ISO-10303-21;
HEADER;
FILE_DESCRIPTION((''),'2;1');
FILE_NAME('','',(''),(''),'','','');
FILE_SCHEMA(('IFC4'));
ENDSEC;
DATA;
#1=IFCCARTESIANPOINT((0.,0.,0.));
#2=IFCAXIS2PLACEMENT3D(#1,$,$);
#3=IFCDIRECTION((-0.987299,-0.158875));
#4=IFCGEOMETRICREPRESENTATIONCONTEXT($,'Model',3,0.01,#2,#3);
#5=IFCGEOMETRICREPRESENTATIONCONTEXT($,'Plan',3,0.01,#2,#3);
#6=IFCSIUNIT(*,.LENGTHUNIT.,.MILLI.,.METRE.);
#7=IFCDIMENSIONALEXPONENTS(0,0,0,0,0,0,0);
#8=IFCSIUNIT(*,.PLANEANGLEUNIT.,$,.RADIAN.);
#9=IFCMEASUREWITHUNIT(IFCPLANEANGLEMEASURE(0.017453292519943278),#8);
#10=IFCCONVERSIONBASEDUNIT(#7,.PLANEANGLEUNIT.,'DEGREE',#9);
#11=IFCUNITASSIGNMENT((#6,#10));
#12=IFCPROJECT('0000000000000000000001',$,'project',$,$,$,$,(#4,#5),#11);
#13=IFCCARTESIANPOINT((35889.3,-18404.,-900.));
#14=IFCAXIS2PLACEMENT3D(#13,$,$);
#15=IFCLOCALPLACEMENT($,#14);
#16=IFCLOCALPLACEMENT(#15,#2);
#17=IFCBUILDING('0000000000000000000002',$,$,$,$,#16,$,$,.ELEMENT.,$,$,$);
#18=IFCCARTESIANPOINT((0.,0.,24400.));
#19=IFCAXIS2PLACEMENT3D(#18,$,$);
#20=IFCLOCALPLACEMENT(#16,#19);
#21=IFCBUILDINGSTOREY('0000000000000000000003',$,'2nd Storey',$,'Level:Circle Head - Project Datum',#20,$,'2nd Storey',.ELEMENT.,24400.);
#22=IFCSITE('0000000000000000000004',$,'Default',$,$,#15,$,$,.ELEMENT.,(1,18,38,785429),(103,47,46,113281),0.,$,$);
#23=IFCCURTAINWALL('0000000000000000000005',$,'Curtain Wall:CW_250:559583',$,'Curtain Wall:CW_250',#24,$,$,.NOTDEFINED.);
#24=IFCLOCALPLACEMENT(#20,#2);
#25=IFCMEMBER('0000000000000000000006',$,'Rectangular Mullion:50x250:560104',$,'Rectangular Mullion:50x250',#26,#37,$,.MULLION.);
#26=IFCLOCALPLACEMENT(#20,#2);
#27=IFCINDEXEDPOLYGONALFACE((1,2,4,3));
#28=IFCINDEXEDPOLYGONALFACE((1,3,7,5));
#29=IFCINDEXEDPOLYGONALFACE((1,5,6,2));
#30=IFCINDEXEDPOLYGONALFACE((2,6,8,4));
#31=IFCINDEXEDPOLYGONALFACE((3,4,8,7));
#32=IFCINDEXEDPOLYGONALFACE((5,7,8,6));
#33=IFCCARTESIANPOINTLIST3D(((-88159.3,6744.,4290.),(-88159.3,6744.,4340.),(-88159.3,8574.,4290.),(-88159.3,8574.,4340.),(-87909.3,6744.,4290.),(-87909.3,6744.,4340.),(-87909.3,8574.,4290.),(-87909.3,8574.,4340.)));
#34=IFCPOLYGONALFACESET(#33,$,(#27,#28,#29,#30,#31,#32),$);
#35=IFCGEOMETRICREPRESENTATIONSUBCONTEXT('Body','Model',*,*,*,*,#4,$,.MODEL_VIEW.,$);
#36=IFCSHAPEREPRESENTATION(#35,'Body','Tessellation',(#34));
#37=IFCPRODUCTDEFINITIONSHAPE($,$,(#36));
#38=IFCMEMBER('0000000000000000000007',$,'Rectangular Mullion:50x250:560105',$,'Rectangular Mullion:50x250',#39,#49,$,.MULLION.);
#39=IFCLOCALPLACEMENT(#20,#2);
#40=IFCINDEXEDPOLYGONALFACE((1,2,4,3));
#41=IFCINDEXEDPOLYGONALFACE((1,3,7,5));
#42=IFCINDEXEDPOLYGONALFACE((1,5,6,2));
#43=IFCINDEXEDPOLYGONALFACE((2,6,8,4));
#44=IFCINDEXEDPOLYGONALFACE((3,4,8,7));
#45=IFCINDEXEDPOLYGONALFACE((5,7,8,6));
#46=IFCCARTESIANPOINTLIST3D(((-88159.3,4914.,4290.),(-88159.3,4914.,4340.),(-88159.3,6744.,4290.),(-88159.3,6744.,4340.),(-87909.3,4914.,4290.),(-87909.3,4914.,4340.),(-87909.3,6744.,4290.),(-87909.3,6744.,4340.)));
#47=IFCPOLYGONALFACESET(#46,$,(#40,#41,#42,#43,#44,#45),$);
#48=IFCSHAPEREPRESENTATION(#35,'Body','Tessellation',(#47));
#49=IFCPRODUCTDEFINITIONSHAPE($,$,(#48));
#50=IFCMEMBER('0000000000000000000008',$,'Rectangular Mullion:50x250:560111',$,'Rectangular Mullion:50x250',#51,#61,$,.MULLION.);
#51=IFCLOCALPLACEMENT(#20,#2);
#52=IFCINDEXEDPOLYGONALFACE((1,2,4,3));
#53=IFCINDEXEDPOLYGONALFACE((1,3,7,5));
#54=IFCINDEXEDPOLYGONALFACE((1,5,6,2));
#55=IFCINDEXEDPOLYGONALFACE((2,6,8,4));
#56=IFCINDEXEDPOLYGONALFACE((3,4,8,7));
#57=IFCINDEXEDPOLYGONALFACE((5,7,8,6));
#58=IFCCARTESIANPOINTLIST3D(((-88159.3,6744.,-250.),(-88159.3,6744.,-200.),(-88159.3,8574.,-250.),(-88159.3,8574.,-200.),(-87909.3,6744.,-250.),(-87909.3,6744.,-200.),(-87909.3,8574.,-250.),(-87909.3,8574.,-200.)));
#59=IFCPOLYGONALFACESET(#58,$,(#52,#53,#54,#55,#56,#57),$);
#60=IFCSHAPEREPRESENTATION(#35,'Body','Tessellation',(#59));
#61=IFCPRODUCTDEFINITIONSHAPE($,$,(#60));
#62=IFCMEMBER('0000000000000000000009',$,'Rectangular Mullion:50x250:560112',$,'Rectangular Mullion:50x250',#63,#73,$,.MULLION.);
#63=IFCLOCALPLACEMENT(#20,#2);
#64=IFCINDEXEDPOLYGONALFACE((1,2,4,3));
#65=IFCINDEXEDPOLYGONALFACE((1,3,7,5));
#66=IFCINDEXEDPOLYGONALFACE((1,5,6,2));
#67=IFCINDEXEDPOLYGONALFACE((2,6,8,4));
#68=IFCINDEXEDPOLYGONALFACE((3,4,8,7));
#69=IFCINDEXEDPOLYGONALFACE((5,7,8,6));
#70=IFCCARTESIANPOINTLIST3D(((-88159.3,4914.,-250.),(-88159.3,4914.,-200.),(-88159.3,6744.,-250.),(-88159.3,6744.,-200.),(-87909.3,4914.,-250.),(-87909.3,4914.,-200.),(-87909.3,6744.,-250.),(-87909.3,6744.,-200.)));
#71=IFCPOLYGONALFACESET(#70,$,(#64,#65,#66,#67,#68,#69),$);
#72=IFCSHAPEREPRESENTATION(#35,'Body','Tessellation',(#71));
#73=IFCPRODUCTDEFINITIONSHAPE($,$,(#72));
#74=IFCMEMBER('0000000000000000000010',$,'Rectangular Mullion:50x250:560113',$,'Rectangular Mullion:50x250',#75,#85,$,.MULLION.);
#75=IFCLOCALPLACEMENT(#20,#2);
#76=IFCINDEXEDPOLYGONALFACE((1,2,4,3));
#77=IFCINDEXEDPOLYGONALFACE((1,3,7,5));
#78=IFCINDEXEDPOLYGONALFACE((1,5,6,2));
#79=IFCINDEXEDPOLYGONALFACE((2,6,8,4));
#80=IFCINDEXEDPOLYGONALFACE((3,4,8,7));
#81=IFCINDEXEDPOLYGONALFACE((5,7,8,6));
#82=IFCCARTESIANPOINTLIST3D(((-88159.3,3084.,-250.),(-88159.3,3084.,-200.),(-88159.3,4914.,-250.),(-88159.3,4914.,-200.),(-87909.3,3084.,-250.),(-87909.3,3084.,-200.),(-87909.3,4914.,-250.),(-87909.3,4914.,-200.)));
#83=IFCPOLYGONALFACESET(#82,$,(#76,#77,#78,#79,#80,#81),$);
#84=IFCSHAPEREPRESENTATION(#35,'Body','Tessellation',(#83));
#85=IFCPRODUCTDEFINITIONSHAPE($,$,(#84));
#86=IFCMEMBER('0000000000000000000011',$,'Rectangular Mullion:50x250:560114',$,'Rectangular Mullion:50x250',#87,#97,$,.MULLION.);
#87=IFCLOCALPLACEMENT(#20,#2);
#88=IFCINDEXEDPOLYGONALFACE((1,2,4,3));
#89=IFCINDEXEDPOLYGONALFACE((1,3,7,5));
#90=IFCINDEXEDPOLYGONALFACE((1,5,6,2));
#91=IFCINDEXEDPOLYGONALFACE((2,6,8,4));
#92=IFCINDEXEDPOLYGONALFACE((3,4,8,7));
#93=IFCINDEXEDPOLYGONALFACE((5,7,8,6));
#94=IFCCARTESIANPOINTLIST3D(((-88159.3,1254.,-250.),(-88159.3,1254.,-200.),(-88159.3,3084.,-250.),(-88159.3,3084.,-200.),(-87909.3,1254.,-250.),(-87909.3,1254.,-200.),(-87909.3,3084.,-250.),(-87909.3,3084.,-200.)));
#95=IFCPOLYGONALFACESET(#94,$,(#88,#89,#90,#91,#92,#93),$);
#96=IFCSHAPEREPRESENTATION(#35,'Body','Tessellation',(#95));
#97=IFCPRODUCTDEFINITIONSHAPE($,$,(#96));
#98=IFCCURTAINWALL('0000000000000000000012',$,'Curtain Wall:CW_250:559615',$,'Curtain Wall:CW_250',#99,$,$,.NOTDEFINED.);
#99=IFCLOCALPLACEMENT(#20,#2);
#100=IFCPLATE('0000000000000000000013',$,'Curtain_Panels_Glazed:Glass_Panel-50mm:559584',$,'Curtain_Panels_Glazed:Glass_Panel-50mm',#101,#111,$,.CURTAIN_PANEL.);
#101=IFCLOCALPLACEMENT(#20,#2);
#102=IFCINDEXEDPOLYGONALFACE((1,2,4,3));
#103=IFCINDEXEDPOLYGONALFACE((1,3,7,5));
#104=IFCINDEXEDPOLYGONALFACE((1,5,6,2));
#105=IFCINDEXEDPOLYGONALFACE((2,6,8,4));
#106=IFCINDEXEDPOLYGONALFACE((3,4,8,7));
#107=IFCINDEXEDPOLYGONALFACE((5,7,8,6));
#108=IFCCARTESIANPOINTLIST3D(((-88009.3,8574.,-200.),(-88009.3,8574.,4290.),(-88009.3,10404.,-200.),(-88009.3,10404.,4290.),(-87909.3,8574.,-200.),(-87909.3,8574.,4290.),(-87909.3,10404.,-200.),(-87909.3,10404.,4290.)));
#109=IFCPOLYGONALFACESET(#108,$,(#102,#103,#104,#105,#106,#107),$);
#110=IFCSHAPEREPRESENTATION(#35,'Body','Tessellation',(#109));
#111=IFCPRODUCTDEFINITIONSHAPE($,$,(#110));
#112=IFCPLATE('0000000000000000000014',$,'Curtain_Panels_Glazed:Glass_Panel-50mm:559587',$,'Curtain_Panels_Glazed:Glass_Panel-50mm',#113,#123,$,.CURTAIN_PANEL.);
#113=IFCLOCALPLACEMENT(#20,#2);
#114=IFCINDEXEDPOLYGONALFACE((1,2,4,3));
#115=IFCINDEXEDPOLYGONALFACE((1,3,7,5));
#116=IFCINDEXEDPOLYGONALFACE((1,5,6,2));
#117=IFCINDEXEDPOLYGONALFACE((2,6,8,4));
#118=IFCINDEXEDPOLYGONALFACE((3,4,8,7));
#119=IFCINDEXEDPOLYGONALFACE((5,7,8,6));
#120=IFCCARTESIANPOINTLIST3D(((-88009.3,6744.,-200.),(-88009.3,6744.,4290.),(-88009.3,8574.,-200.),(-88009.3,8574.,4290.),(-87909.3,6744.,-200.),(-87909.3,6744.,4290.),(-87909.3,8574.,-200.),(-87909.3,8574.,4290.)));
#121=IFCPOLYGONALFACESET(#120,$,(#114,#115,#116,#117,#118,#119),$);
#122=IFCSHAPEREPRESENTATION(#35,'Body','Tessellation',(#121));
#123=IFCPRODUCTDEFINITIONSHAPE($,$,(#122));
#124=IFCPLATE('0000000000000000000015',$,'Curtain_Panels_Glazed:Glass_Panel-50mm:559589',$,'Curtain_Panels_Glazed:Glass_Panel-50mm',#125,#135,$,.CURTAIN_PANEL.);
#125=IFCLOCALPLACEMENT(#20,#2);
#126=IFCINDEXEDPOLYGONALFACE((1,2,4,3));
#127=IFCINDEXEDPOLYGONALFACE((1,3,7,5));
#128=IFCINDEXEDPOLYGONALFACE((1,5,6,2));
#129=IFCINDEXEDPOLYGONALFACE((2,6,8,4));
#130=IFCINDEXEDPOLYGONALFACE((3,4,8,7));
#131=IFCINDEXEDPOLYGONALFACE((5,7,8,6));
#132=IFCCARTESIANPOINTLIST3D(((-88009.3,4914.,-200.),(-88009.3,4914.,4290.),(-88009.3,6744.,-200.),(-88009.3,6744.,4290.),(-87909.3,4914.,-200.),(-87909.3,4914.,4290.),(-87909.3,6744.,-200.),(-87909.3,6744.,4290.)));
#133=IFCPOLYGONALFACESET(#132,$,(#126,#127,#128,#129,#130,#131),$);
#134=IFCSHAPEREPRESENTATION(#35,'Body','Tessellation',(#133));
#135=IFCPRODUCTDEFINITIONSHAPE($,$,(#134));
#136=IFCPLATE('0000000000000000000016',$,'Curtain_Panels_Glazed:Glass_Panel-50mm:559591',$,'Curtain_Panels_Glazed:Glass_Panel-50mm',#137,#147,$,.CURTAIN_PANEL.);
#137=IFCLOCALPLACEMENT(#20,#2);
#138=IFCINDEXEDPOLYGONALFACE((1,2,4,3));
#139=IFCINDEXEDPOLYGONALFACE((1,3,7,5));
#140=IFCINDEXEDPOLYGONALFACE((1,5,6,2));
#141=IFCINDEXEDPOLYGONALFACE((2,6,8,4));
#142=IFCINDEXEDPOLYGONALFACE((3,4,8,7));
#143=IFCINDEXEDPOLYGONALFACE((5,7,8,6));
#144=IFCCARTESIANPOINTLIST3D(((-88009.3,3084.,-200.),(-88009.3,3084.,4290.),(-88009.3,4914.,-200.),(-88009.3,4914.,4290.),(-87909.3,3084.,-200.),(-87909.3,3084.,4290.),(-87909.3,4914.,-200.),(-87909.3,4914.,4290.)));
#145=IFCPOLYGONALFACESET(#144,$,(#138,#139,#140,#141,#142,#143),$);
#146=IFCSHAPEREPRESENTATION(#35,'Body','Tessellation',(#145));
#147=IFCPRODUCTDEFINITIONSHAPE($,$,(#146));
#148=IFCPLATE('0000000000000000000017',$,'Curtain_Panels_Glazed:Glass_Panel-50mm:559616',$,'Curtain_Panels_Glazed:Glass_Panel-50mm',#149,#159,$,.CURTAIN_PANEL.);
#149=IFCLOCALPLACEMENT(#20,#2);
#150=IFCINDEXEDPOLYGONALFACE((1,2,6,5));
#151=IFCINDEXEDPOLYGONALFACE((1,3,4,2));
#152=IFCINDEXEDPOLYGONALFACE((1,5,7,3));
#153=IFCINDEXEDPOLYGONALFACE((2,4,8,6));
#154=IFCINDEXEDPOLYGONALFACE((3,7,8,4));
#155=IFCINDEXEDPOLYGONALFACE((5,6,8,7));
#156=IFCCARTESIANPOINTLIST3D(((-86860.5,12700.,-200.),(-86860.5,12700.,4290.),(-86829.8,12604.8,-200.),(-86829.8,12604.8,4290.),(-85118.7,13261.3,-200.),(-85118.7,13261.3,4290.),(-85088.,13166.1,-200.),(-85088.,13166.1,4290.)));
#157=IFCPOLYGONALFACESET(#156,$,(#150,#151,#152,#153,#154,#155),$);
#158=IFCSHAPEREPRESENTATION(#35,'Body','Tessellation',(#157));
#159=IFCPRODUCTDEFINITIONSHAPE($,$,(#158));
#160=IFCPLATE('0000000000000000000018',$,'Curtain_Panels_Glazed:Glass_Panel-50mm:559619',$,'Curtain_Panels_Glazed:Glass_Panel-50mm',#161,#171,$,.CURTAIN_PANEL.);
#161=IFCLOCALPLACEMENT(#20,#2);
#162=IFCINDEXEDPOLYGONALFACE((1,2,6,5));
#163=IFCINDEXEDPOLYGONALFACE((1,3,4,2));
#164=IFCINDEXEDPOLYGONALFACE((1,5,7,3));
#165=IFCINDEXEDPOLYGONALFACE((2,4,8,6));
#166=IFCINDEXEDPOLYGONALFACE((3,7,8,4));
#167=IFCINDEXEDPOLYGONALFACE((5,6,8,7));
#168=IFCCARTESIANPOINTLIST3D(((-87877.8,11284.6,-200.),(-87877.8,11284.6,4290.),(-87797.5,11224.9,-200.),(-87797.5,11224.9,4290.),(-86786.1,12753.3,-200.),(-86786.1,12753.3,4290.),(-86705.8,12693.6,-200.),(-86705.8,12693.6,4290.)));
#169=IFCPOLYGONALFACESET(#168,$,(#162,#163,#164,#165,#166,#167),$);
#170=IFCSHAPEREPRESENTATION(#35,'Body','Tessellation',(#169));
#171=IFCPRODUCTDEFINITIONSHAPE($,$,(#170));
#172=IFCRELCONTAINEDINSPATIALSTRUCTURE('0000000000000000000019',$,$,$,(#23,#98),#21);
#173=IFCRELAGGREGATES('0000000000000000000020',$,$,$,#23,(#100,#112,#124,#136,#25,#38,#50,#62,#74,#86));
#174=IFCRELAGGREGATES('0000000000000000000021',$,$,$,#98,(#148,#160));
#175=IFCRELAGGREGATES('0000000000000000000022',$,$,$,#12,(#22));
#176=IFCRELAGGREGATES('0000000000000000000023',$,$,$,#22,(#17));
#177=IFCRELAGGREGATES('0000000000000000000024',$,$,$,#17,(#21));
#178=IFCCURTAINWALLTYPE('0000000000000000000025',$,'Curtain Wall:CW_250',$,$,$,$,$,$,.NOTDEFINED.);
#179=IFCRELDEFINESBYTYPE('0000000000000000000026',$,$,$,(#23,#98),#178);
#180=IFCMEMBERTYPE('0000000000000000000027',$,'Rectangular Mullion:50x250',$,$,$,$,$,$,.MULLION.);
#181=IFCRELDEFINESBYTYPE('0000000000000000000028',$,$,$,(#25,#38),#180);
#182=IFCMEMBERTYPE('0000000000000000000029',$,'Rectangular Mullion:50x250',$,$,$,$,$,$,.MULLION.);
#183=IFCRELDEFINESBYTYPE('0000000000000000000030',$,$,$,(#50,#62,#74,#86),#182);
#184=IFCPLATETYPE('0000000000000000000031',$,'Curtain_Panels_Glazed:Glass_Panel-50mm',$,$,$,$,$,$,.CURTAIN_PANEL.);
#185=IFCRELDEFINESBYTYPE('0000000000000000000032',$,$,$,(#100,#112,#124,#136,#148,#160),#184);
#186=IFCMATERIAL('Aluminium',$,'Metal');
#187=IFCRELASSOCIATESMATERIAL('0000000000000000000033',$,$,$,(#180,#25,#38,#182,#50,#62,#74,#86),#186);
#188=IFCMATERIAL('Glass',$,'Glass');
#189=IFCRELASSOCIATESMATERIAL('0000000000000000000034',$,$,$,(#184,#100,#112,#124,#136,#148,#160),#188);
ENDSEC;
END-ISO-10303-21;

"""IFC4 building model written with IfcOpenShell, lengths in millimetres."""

from ifc_helpers import new_model, entity, si_unit, converted_unit, direction, frame, origin, place, context, subcontext, project, spatial, indexed_curve, outline, extrude, source, transform, mapped, material, type_object, type_shapes, element, aggregate, save


model = new_model("IFC4")

# Units and contexts
model_context = context("Model", 3, precision=0.01, world=origin(), true_north=direction((-0.987299, -0.158875)))
plan_context = context("Plan", 3, precision=0.01, world=origin(), true_north=direction((-0.987299, -0.158875)))
body_context = subcontext(model_context, "Body", "Model", "MODEL_VIEW")
ifc_project = project(units=[si_unit("LENGTHUNIT", "METRE", prefix="MILLI"), converted_unit("PLANEANGLEUNIT", "DEGREE", entity("IfcPlaneAngleMeasure", 0.017453292519943278), si_unit("PLANEANGLEUNIT", "RADIAN"), dimensions=[0, 0, 0, 0, 0, 0, 0])], contexts=[model_context, plan_context])

# Site, building, storey
site_placement = place(None, frame((35889.3, -18404.0, -900.0)))
site = spatial("IfcSite", under=ifc_project, at=site_placement, Name="Default", CompositionType="ELEMENT", RefLatitude=(1, 18, 38, 785429), RefLongitude=(103, 47, 46, 113281), RefElevation=0.0)
building_placement = place(site_placement, origin())
building = spatial("IfcBuilding", under=site, at=building_placement, CompositionType="ELEMENT")
storey_placement = place(building_placement, frame((0.0, 0.0, 24400.0)))
storey = spatial("IfcBuildingStorey", under=building, at=storey_placement, Name="2nd Storey", ObjectType="Level:Circle Head - Project Datum", LongName="2nd Storey", CompositionType="ELEMENT", Elevation=24400.0)

# Curtain walls, members
curtain_wall_type = type_object("IfcCurtainWallType", Name="Curtain Wall:CW_250", PredefinedType="NOTDEFINED")
curtain_wall_1_placement = place(storey_placement, frame((0.0, 0.0, -24400.0)))
curtain_wall_1 = element("IfcCurtainWall", 1, at=curtain_wall_1_placement, inside=storey, type_object=curtain_wall_type, Name="Curtain Wall:CW_250:559583", ObjectType="Curtain Wall:CW_250", PredefinedType="NOTDEFINED")
ifc_material_1 = material(Name="Aluminium", Category="Metal")
member_type_1 = type_object("IfcMemberType", Name="Rectangular Mullion:50x250", PredefinedType="MULLION", material=ifc_material_1)
shared_shape_1 = source(origin(), body_context, "Body", "SweptSolid", [
    extrude(outline(indexed_curve([(-25.0, -125.0), (25.0, -125.0), (25.0, 125.0), (-25.0, 125.0), (-25.0, -125.0)], self_intersect=False)), frame((-25.0, -125.0, -1830.0), z_axis=(0.0, 0.0, 1.0), x_axis=(-1.0, 0.0, 0.0)), (0.0, 0.0, 1.0), 1830.0),
])
type_shapes(member_type_1, [shared_shape_1])
member_1_placement = place(curtain_wall_1_placement, frame((-88159.3, 6744.0, 28740.0), z_axis=(0.0, -1.0, 0.0), x_axis=(0.0, 0.0, 1.0)))
member_1 = element("IfcMember", 2, at=member_1_placement, type_object=member_type_1, material=ifc_material_1, Name="Rectangular Mullion:50x250:560104", ObjectType="Rectangular Mullion:50x250", PredefinedType="MULLION", context=body_context, shape_type="MappedRepresentation", body=[
    mapped(shared_shape_1, transform((0.0, 0.0, 0.0), scale=1.0)),
])
member_2_placement = place(curtain_wall_1_placement, frame((-88159.3, 4914.0, 28740.0), z_axis=(0.0, -1.0, 0.0), x_axis=(0.0, 0.0, 1.0)))
member_2 = element("IfcMember", 3, at=member_2_placement, type_object=member_type_1, material=ifc_material_1, Name="Rectangular Mullion:50x250:560105", ObjectType="Rectangular Mullion:50x250", PredefinedType="MULLION", context=body_context, shape_type="MappedRepresentation", body=[
    mapped(shared_shape_1, transform((0.0, 0.0, 0.0), scale=1.0)),
])
member_type_2 = type_object("IfcMemberType", Name="Rectangular Mullion:50x250", PredefinedType="MULLION", material=ifc_material_1)
shared_shape_2 = source(origin(), body_context, "Body", "SweptSolid", [
    extrude(outline(indexed_curve([(-25.0, -125.0), (25.0, -125.0), (25.0, 125.0), (-25.0, 125.0), (-25.0, -125.0)], self_intersect=False)), frame((-25.0, -125.0, -1830.0), z_axis=(0.0, 0.0, 1.0), x_axis=(-1.0, 0.0, 0.0)), (0.0, 0.0, 1.0), 1830.0),
])
type_shapes(member_type_2, [shared_shape_2])
member_3_placement = place(curtain_wall_1_placement, frame((-88159.3, 8574.0, 24150.0), z_axis=(0.0, 1.0, 0.0), x_axis=(0.0, 0.0, -1.0)))
member_3 = element("IfcMember", 4, at=member_3_placement, type_object=member_type_2, material=ifc_material_1, Name="Rectangular Mullion:50x250:560111", ObjectType="Rectangular Mullion:50x250", PredefinedType="MULLION", context=body_context, shape_type="MappedRepresentation", body=[
    mapped(shared_shape_2, transform((0.0, 0.0, 0.0), scale=1.0)),
])
member_4_placement = place(curtain_wall_1_placement, frame((-88159.3, 6744.0, 24150.0), z_axis=(0.0, 1.0, 0.0), x_axis=(0.0, 0.0, -1.0)))
member_4 = element("IfcMember", 5, at=member_4_placement, type_object=member_type_2, material=ifc_material_1, Name="Rectangular Mullion:50x250:560112", ObjectType="Rectangular Mullion:50x250", PredefinedType="MULLION", context=body_context, shape_type="MappedRepresentation", body=[
    mapped(shared_shape_2, transform((0.0, 0.0, 0.0), scale=1.0)),
])
member_5_placement = place(curtain_wall_1_placement, frame((-88159.3, 4914.0, 24150.0), z_axis=(0.0, 1.0, 0.0), x_axis=(0.0, 0.0, -1.0)))
member_5 = element("IfcMember", 6, at=member_5_placement, type_object=member_type_2, material=ifc_material_1, Name="Rectangular Mullion:50x250:560113", ObjectType="Rectangular Mullion:50x250", PredefinedType="MULLION", context=body_context, shape_type="MappedRepresentation", body=[
    mapped(shared_shape_2, transform((0.0, 0.0, 0.0), scale=1.0)),
])
member_6_placement = place(curtain_wall_1_placement, frame((-88159.3, 3084.0, 24150.0), z_axis=(0.0, 1.0, 0.0), x_axis=(0.0, 0.0, -1.0)))
member_6 = element("IfcMember", 7, at=member_6_placement, type_object=member_type_2, material=ifc_material_1, Name="Rectangular Mullion:50x250:560114", ObjectType="Rectangular Mullion:50x250", PredefinedType="MULLION", context=body_context, shape_type="MappedRepresentation", body=[
    mapped(shared_shape_2, transform((0.0, 0.0, 0.0), scale=1.0)),
])
curtain_wall_2_placement = place(storey_placement, frame((0.0, 0.0, -24400.0)))
curtain_wall_2 = element("IfcCurtainWall", 8, at=curtain_wall_2_placement, inside=storey, type_object=curtain_wall_type, Name="Curtain Wall:CW_250:559615", ObjectType="Curtain Wall:CW_250", PredefinedType="NOTDEFINED")

# Plates
ifc_material_2 = material(Name="Glass", Category="Glass")
plate_type_1 = type_object("IfcPlateType", Name="Curtain_Panels_Glazed:Glass_Panel-50mm", PredefinedType="CURTAIN_PANEL", material=ifc_material_2)
shared_shape_3 = source(origin(), body_context, "Body", "SweptSolid", [
    extrude(outline(indexed_curve([(-50.0, -915.0), (50.0, -915.0), (50.0, 915.0), (-50.0, 915.0), (-50.0, -915.0)], self_intersect=False)), frame((0.0, 200.0, 0.0), z_axis=(0.0, 0.0, 1.0), x_axis=(0.0, 1.0, 0.0)), (0.0, 0.0, 1.0), 4490.0),
])
type_shapes(plate_type_1, [shared_shape_3])
plate_1_placement = place(curtain_wall_1_placement, frame((-88159.3, 9489.0, 24200.0), z_axis=(0.0, 0.0, 1.0), x_axis=(0.0, -1.0, 0.0)))
plate_1 = element("IfcPlate", 9, at=plate_1_placement, type_object=plate_type_1, material=ifc_material_2, Name="Curtain_Panels_Glazed:Glass_Panel-50mm:559584", ObjectType="Curtain_Panels_Glazed:Glass_Panel-50mm", PredefinedType="CURTAIN_PANEL", context=body_context, shape_type="MappedRepresentation", body=[
    mapped(shared_shape_3, transform((0.0, 0.0, 0.0), scale=1.0)),
])
plate_2_placement = place(curtain_wall_1_placement, frame((-88159.3, 7659.0, 24200.0), z_axis=(0.0, 0.0, 1.0), x_axis=(0.0, -1.0, 0.0)))
plate_2 = element("IfcPlate", 10, at=plate_2_placement, type_object=plate_type_1, material=ifc_material_2, Name="Curtain_Panels_Glazed:Glass_Panel-50mm:559587", ObjectType="Curtain_Panels_Glazed:Glass_Panel-50mm", PredefinedType="CURTAIN_PANEL", context=body_context, shape_type="MappedRepresentation", body=[
    mapped(shared_shape_3, transform((0.0, 0.0, 0.0), scale=1.0)),
])
plate_3_placement = place(curtain_wall_1_placement, frame((-88159.3, 5829.0, 24200.0), z_axis=(0.0, 0.0, 1.0), x_axis=(0.0, -1.0, 0.0)))
plate_3 = element("IfcPlate", 11, at=plate_3_placement, type_object=plate_type_1, material=ifc_material_2, Name="Curtain_Panels_Glazed:Glass_Panel-50mm:559589", ObjectType="Curtain_Panels_Glazed:Glass_Panel-50mm", PredefinedType="CURTAIN_PANEL", context=body_context, shape_type="MappedRepresentation", body=[
    mapped(shared_shape_3, transform((0.0, 0.0, 0.0), scale=1.0)),
])
plate_4_placement = place(curtain_wall_1_placement, frame((-88159.3, 3999.0, 24200.0), z_axis=(0.0, 0.0, 1.0), x_axis=(0.0, -1.0, 0.0)))
plate_4 = element("IfcPlate", 12, at=plate_4_placement, type_object=plate_type_1, material=ifc_material_2, Name="Curtain_Panels_Glazed:Glass_Panel-50mm:559591", ObjectType="Curtain_Panels_Glazed:Glass_Panel-50mm", PredefinedType="CURTAIN_PANEL", context=body_context, shape_type="MappedRepresentation", body=[
    mapped(shared_shape_3, transform((0.0, 0.0, 0.0), scale=1.0)),
])
aggregate(curtain_wall_1, [plate_1, plate_2, plate_3, plate_4, member_1, member_2, member_3, member_4, member_5, member_6])
plate_5_placement = place(curtain_wall_2_placement, frame((-86035.6, 13123.4, 24200.0), z_axis=(0.0, 0.0, 1.0), x_axis=(-0.951803, -0.306709, 0.0)))
plate_5 = element("IfcPlate", 13, at=plate_5_placement, type_object=plate_type_1, material=ifc_material_2, Name="Curtain_Panels_Glazed:Glass_Panel-50mm:559616", ObjectType="Curtain_Panels_Glazed:Glass_Panel-50mm", PredefinedType="CURTAIN_PANEL", context=body_context, shape_type="MappedRepresentation", body=[
    mapped(shared_shape_3, transform((0.0, 0.0, 0.0), scale=1.0)),
])
plate_6_placement = place(curtain_wall_2_placement, frame((-87452.3, 12108.4, 24200.0), z_axis=(0.0, 0.0, 1.0), x_axis=(-0.596543, -0.802581, 0.0)))
plate_6 = element("IfcPlate", 14, at=plate_6_placement, type_object=plate_type_1, material=ifc_material_2, Name="Curtain_Panels_Glazed:Glass_Panel-50mm:559619", ObjectType="Curtain_Panels_Glazed:Glass_Panel-50mm", PredefinedType="CURTAIN_PANEL", context=body_context, shape_type="MappedRepresentation", body=[
    mapped(shared_shape_3, transform((0.0, 0.0, 0.0), scale=1.0)),
])
aggregate(curtain_wall_2, [plate_5, plate_6])

save(model, "model.ifc")
